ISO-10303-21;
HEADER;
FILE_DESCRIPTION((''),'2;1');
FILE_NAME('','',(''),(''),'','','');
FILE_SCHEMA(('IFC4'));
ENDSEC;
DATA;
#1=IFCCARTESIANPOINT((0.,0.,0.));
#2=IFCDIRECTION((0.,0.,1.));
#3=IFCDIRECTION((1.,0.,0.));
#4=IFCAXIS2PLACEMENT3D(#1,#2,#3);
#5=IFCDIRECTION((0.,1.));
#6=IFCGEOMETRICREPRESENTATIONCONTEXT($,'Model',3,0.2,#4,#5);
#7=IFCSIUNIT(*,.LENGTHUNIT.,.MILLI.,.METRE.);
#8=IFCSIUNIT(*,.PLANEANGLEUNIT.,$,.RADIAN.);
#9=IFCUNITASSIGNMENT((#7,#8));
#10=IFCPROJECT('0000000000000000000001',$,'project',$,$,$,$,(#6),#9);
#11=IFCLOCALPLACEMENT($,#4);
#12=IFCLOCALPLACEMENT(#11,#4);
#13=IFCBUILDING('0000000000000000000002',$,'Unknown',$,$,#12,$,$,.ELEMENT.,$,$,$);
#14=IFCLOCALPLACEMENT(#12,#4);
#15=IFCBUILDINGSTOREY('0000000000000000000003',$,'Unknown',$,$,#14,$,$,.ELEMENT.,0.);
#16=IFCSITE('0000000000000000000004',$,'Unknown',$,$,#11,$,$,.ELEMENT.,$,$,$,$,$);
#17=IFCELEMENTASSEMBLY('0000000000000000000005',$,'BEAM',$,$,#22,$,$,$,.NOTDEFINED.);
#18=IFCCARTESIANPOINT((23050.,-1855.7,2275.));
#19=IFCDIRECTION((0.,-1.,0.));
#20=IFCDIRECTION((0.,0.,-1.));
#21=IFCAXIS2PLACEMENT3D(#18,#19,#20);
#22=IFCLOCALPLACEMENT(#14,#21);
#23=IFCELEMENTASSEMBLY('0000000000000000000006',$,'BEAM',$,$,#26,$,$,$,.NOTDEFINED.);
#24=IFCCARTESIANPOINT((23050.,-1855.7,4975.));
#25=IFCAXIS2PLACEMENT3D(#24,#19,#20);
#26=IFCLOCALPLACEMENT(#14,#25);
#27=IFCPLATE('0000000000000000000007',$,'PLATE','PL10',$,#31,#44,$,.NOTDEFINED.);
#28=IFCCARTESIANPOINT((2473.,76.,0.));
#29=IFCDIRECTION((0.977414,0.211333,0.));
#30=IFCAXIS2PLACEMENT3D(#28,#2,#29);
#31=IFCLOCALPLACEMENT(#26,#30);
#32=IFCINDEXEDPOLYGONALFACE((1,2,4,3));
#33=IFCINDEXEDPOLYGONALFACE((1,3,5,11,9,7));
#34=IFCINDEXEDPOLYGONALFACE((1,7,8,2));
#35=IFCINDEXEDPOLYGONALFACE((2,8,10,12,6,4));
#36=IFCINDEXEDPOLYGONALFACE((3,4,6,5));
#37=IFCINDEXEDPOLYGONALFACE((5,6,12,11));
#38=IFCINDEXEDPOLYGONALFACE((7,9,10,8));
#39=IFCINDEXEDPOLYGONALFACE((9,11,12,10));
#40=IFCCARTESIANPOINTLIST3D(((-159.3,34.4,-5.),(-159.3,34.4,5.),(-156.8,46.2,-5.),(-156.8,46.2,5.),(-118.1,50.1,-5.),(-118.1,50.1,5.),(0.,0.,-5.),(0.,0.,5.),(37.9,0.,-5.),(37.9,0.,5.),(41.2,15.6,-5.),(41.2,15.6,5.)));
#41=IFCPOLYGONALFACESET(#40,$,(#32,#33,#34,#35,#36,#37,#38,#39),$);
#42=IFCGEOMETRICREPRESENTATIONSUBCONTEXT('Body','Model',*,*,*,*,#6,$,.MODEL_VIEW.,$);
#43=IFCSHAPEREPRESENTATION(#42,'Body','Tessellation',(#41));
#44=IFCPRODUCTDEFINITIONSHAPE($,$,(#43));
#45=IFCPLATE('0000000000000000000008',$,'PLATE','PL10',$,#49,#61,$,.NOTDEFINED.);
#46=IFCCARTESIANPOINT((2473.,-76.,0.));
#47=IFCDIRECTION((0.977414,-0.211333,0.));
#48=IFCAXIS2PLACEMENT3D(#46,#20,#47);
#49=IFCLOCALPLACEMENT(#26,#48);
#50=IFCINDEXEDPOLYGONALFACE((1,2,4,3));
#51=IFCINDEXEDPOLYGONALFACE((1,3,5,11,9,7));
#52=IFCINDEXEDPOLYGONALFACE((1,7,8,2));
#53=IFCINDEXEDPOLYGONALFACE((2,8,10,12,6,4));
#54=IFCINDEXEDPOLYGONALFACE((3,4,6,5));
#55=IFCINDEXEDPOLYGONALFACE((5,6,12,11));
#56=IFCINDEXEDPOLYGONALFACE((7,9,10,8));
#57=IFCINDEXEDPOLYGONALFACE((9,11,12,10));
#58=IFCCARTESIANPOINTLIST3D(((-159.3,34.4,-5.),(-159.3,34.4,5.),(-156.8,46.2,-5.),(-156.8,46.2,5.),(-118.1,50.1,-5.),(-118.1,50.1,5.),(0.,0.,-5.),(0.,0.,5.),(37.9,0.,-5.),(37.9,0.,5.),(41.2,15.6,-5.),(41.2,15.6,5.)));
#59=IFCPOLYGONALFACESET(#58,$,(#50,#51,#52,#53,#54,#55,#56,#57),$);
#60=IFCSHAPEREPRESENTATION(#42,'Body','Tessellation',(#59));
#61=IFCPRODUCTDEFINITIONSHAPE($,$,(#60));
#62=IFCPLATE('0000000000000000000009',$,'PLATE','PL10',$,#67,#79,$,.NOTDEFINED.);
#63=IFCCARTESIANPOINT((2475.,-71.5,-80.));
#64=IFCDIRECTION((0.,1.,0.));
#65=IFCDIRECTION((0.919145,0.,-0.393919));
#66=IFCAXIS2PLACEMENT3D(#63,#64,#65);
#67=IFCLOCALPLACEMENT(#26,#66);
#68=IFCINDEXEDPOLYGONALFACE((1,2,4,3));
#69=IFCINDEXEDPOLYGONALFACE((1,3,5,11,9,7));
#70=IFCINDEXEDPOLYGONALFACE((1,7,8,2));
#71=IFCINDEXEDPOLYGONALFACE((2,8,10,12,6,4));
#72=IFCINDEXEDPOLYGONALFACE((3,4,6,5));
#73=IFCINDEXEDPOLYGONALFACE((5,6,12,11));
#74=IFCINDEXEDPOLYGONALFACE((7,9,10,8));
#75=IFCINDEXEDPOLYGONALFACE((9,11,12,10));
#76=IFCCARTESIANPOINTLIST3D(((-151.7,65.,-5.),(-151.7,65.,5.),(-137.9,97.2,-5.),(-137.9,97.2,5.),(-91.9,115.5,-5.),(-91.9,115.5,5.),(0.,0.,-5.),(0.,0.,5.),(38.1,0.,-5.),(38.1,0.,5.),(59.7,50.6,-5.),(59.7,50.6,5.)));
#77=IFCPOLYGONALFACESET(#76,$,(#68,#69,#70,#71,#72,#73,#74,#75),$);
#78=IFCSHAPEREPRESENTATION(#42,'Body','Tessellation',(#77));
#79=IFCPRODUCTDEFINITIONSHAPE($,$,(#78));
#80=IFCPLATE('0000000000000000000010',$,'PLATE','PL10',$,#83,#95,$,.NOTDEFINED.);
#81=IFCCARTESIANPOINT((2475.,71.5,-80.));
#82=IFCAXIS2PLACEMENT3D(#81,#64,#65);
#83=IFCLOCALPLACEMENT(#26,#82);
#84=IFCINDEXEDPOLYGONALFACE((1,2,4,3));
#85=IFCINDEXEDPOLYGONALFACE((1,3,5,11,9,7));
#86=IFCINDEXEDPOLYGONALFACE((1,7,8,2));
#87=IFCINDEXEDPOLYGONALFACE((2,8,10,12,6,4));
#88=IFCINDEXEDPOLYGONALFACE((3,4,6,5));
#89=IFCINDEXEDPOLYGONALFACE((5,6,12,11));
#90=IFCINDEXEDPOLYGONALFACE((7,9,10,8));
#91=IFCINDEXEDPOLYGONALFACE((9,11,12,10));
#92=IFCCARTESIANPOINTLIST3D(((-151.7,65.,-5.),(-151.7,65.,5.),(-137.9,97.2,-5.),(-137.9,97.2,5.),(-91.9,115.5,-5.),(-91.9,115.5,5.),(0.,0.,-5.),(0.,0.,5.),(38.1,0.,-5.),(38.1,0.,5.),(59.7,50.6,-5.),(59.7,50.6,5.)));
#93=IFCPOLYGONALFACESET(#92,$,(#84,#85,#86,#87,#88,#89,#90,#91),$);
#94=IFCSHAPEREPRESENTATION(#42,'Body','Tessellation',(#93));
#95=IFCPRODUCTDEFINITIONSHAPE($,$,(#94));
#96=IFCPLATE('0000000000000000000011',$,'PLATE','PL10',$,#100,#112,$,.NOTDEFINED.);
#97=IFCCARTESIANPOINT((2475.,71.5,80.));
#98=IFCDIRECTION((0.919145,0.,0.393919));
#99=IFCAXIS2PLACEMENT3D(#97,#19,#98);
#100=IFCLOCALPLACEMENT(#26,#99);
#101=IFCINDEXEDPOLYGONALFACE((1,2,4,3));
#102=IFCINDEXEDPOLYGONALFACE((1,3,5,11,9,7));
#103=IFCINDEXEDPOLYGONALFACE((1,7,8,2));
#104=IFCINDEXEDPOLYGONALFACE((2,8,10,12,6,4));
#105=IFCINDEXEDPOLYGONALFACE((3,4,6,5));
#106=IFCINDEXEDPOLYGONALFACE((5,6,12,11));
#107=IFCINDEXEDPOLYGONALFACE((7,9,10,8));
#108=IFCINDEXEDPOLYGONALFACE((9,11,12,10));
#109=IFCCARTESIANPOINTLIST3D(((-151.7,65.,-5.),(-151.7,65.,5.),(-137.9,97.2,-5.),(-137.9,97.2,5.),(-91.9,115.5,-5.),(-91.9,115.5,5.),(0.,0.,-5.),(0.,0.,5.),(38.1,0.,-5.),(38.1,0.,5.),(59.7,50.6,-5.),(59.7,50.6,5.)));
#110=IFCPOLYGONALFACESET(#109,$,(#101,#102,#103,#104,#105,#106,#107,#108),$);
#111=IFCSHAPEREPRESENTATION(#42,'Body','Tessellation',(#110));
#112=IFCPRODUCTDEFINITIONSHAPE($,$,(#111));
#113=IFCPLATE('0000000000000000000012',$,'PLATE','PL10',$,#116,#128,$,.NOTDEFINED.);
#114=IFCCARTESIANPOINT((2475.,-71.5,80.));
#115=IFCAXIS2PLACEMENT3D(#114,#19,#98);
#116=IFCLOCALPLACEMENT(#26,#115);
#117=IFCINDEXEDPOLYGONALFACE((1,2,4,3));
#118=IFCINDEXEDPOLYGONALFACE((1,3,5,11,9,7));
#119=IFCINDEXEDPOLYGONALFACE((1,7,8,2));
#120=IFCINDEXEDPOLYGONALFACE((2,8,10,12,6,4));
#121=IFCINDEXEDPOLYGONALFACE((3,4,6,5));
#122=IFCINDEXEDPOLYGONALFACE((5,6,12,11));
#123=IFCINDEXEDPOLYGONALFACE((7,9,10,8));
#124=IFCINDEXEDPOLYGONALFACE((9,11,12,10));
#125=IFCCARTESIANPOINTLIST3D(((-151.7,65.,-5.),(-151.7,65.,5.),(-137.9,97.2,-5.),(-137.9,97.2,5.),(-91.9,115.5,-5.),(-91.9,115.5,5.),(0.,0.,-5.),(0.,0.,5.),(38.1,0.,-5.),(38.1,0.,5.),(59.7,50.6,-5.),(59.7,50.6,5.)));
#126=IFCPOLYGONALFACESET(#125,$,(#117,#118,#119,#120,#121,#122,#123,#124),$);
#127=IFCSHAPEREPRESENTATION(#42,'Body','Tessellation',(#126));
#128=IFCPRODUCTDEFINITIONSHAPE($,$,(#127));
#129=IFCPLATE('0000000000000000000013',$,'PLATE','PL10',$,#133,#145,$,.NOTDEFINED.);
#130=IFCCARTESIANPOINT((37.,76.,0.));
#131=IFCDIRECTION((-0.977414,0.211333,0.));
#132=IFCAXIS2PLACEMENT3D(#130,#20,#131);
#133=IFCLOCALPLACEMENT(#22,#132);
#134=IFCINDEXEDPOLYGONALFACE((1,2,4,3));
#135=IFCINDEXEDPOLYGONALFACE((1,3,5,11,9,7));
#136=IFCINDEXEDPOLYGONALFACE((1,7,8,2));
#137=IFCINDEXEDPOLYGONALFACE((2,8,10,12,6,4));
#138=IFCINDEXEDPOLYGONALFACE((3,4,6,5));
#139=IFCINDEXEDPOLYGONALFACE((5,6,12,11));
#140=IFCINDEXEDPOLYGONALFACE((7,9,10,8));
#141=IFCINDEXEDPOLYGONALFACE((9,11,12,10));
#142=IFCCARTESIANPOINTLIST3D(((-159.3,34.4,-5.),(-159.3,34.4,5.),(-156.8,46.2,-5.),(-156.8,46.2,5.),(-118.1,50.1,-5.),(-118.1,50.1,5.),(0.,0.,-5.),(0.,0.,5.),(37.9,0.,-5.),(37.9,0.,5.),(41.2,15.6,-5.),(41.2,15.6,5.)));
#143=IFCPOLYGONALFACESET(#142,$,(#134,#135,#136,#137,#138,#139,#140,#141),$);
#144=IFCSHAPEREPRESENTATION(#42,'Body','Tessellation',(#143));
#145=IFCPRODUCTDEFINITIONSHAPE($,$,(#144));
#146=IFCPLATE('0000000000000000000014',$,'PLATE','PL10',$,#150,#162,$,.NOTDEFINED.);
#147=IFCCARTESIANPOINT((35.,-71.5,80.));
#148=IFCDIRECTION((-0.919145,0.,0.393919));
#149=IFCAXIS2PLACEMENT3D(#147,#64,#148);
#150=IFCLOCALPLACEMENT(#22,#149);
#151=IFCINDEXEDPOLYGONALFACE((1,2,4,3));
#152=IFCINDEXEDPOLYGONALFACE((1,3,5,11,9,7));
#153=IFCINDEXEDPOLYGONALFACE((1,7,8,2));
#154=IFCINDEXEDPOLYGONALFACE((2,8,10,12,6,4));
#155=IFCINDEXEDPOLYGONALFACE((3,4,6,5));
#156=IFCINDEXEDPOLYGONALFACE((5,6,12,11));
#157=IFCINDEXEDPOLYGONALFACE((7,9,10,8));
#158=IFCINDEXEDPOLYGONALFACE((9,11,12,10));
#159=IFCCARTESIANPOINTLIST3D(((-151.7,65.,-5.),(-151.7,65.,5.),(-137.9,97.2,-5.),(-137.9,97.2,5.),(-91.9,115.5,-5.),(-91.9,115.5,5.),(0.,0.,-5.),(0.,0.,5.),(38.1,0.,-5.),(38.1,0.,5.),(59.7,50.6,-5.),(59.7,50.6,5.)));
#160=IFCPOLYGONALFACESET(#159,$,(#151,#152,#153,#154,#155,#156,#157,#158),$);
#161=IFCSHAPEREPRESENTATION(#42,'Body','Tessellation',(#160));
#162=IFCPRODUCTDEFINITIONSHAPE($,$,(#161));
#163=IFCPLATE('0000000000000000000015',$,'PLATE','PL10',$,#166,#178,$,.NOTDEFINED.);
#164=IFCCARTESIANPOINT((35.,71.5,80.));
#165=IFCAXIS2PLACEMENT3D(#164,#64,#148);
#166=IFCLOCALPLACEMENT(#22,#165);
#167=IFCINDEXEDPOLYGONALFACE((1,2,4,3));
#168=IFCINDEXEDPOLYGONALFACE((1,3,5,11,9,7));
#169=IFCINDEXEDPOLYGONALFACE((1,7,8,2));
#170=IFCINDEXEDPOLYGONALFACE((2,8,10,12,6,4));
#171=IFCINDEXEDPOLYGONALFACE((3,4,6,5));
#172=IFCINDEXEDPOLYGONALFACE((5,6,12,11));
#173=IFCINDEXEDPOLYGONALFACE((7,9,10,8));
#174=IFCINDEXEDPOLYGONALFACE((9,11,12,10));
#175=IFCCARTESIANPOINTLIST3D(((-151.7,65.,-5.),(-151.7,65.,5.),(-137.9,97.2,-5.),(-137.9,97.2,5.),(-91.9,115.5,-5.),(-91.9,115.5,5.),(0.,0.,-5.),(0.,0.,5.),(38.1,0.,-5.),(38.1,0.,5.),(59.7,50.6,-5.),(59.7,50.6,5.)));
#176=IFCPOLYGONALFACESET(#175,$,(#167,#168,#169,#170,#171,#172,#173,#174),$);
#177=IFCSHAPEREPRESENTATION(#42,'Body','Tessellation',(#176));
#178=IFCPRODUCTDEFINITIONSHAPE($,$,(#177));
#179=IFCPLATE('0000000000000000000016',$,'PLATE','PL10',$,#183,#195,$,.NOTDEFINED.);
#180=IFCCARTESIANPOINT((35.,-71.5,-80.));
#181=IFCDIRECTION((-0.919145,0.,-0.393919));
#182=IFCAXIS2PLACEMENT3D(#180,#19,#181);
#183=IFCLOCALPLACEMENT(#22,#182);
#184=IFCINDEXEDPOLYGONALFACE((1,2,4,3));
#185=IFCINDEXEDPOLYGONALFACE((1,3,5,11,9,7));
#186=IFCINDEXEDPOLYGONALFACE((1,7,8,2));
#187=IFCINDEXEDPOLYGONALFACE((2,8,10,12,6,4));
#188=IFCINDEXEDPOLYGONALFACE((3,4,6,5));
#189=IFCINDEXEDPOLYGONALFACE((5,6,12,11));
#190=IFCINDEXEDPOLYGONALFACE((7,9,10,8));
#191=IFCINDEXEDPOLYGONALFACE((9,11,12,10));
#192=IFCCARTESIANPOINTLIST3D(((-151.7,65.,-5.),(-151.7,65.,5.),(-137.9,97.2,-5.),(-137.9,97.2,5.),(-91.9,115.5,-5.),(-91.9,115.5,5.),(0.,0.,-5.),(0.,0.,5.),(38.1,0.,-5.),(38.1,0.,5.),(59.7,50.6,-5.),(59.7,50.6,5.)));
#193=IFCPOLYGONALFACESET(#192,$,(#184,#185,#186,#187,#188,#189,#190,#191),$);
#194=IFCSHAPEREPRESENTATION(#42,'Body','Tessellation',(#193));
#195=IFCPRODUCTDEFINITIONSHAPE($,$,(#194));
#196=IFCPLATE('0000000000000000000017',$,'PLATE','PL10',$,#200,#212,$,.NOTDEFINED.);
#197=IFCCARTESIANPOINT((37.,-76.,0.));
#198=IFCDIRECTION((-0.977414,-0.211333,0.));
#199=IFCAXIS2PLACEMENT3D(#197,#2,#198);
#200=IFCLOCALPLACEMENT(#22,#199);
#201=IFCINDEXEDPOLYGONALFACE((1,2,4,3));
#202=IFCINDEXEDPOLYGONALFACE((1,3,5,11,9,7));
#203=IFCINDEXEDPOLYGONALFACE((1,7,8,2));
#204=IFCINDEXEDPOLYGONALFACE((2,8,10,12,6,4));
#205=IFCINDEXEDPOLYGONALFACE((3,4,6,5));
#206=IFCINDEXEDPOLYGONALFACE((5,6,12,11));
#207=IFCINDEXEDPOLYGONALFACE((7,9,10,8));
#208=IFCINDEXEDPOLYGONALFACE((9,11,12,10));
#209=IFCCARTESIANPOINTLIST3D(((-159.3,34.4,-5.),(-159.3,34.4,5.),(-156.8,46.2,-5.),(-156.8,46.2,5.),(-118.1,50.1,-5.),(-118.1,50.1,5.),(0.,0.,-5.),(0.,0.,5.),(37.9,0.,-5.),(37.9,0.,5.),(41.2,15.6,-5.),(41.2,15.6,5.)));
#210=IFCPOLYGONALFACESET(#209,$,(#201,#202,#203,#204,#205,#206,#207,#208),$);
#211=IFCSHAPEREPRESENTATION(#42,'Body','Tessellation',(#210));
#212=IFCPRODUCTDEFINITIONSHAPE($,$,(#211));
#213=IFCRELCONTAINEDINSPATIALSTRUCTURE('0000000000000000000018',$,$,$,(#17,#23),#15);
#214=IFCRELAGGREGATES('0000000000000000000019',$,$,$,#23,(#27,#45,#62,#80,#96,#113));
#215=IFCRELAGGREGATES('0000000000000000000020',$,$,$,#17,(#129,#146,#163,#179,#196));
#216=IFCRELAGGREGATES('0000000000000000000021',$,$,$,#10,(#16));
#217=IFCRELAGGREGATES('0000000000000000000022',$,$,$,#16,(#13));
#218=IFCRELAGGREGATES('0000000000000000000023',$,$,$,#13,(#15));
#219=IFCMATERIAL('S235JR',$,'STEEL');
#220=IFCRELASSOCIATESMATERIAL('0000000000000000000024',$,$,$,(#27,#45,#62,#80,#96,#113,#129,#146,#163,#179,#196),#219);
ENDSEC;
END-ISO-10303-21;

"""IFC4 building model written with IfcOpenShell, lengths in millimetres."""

from ifc_helpers import new_model, si_unit, direction, frame, origin_with_axes, place, context, subcontext, project, spatial, line, indexed_curve, outline, extrude, material, element, aggregate, save


model = new_model("IFC4")

# Units and contexts
model_context = context("Model", 3, precision=0.2, world=origin_with_axes(), true_north=direction((0.0, 1.0)))
body_context = subcontext(model_context, "Body", "Model", "MODEL_VIEW")
ifc_project = project(units=[si_unit("LENGTHUNIT", "METRE", prefix="MILLI"), si_unit("PLANEANGLEUNIT", "RADIAN")], contexts=[model_context])

# Site, building, storey
site_placement = place(None, origin_with_axes())
site = spatial("IfcSite", under=ifc_project, at=site_placement, Name="Unknown", CompositionType="ELEMENT")
building_placement = place(site_placement, origin_with_axes())
building = spatial("IfcBuilding", under=site, at=building_placement, Name="Unknown", CompositionType="ELEMENT")
storey_placement = place(building_placement, origin_with_axes())
storey = spatial("IfcBuildingStorey", under=building, at=storey_placement, Name="Unknown", CompositionType="ELEMENT", Elevation=0.0)

# Shared definitions
ifc_material_1 = material(Name="S235JR", Category="STEEL")

# Element assembly
assembly_1_placement = place(storey_placement, frame((23050.0, -1855.7, 2275.0), z_axis=(0.0, -1.0, 0.0), x_axis=(0.0, 0.0, -1.0)))
assembly_1 = element("IfcElementAssembly", 1, at=assembly_1_placement, inside=storey, Name="BEAM", PredefinedType="NOTDEFINED")

# Element assembly, plates
assembly_2_placement = place(storey_placement, frame((23050.0, -1855.7, 4975.0), z_axis=(0.0, -1.0, 0.0), x_axis=(0.0, 0.0, -1.0)))
assembly_2 = element("IfcElementAssembly", 2, at=assembly_2_placement, inside=storey, Name="BEAM", PredefinedType="NOTDEFINED")
plate_1_placement = place(assembly_2_placement, frame((2473.0, 76.0, 0.0), z_axis=(0.0, 0.0, 1.0), x_axis=(0.977414, 0.211333, 0.0)))
plate_1 = element("IfcPlate", 3, at=plate_1_placement, material=ifc_material_1, Name="PLATE", Description="PL10", PredefinedType="NOTDEFINED", context=body_context, shape_type="SolidModel", body=[
    extrude(outline(indexed_curve([(0.0, 0.0), (37.9, 0.0), (41.2, 15.6), (-118.1, 50.1), (-156.8, 46.2), (-159.3, 34.4)], segments=[line(1, 2, 3, 4, 5, 6, 1)])), frame((0.0, 0.0, 5.0), z_axis=(0.0, 0.0, 1.0), x_axis=(1.0, 0.0, 0.0)), (0.0, 0.0, -1.0), 10.0),
])
plate_2_placement = place(assembly_2_placement, frame((2473.0, -76.0, 0.0), z_axis=(0.0, 0.0, -1.0), x_axis=(0.977414, -0.211333, 0.0)))
plate_2 = element("IfcPlate", 4, at=plate_2_placement, material=ifc_material_1, Name="PLATE", Description="PL10", PredefinedType="NOTDEFINED", context=body_context, shape_type="SolidModel", body=[
    extrude(outline(indexed_curve([(0.0, 0.0), (37.9, 0.0), (41.2, 15.6), (-118.1, 50.1), (-156.8, 46.2), (-159.3, 34.4)], segments=[line(1, 2, 3, 4, 5, 6, 1)])), frame((0.0, 0.0, 5.0), z_axis=(0.0, 0.0, 1.0), x_axis=(1.0, 0.0, 0.0)), (0.0, 0.0, -1.0), 10.0),
])
plate_3_placement = place(assembly_2_placement, frame((2475.0, -71.5, -80.0), z_axis=(0.0, 1.0, 0.0), x_axis=(0.919145, 0.0, -0.393919)))
plate_3 = element("IfcPlate", 5, at=plate_3_placement, material=ifc_material_1, Name="PLATE", Description="PL10", PredefinedType="NOTDEFINED", context=body_context, shape_type="SolidModel", body=[
    extrude(outline(indexed_curve([(0.0, 0.0), (38.1, 0.0), (59.7, 50.6), (-91.9, 115.5), (-137.9, 97.2), (-151.7, 65.0)], segments=[line(1, 2, 3, 4, 5, 6, 1)])), frame((0.0, 0.0, 5.0), z_axis=(0.0, 0.0, 1.0), x_axis=(1.0, 0.0, 0.0)), (0.0, 0.0, -1.0), 10.0),
])
plate_4_placement = place(assembly_2_placement, frame((2475.0, 71.5, -80.0), z_axis=(0.0, 1.0, 0.0), x_axis=(0.919145, 0.0, -0.393919)))
plate_4 = element("IfcPlate", 6, at=plate_4_placement, material=ifc_material_1, Name="PLATE", Description="PL10", PredefinedType="NOTDEFINED", context=body_context, shape_type="SolidModel", body=[
    extrude(outline(indexed_curve([(0.0, 0.0), (38.1, 0.0), (59.7, 50.6), (-91.9, 115.5), (-137.9, 97.2), (-151.7, 65.0)], segments=[line(1, 2, 3, 4, 5, 6, 1)])), frame((0.0, 0.0, 5.0), z_axis=(0.0, 0.0, 1.0), x_axis=(1.0, 0.0, 0.0)), (0.0, 0.0, -1.0), 10.0),
])
plate_5_placement = place(assembly_2_placement, frame((2475.0, 71.5, 80.0), z_axis=(0.0, -1.0, 0.0), x_axis=(0.919145, 0.0, 0.393919)))
plate_5 = element("IfcPlate", 7, at=plate_5_placement, material=ifc_material_1, Name="PLATE", Description="PL10", PredefinedType="NOTDEFINED", context=body_context, shape_type="SolidModel", body=[
    extrude(outline(indexed_curve([(0.0, 0.0), (38.1, 0.0), (59.7, 50.6), (-91.9, 115.5), (-137.9, 97.2), (-151.7, 65.0)], segments=[line(1, 2, 3, 4, 5, 6, 1)])), frame((0.0, 0.0, 5.0), z_axis=(0.0, 0.0, 1.0), x_axis=(1.0, 0.0, 0.0)), (0.0, 0.0, -1.0), 10.0),
])
plate_6_placement = place(assembly_2_placement, frame((2475.0, -71.5, 80.0), z_axis=(0.0, -1.0, 0.0), x_axis=(0.919145, 0.0, 0.393919)))
plate_6 = element("IfcPlate", 8, at=plate_6_placement, material=ifc_material_1, Name="PLATE", Description="PL10", PredefinedType="NOTDEFINED", context=body_context, shape_type="SolidModel", body=[
    extrude(outline(indexed_curve([(0.0, 0.0), (38.1, 0.0), (59.7, 50.6), (-91.9, 115.5), (-137.9, 97.2), (-151.7, 65.0)], segments=[line(1, 2, 3, 4, 5, 6, 1)])), frame((0.0, 0.0, 5.0), z_axis=(0.0, 0.0, 1.0), x_axis=(1.0, 0.0, 0.0)), (0.0, 0.0, -1.0), 10.0),
])
aggregate(assembly_2, [plate_1, plate_2, plate_3, plate_4, plate_5, plate_6])

# Plates
plate_7_placement = place(assembly_1_placement, frame((37.0, 76.0, 0.0), z_axis=(0.0, 0.0, -1.0), x_axis=(-0.977414, 0.211333, 0.0)))
plate_7 = element("IfcPlate", 9, at=plate_7_placement, material=ifc_material_1, Name="PLATE", Description="PL10", PredefinedType="NOTDEFINED", context=body_context, shape_type="SolidModel", body=[
    extrude(outline(indexed_curve([(0.0, 0.0), (37.9, 0.0), (41.2, 15.6), (-118.1, 50.1), (-156.8, 46.2), (-159.3, 34.4)], segments=[line(1, 2, 3, 4, 5, 6, 1)])), frame((0.0, 0.0, 5.0), z_axis=(0.0, 0.0, 1.0), x_axis=(1.0, 0.0, 0.0)), (0.0, 0.0, -1.0), 10.0),
])
plate_8_placement = place(assembly_1_placement, frame((35.0, -71.5, 80.0), z_axis=(0.0, 1.0, 0.0), x_axis=(-0.919145, 0.0, 0.393919)))
plate_8 = element("IfcPlate", 10, at=plate_8_placement, material=ifc_material_1, Name="PLATE", Description="PL10", PredefinedType="NOTDEFINED", context=body_context, shape_type="SolidModel", body=[
    extrude(outline(indexed_curve([(0.0, 0.0), (38.1, 0.0), (59.7, 50.6), (-91.9, 115.5), (-137.9, 97.2), (-151.7, 65.0)], segments=[line(1, 2, 3, 4, 5, 6, 1)])), frame((0.0, 0.0, 5.0), z_axis=(0.0, 0.0, 1.0), x_axis=(1.0, 0.0, 0.0)), (0.0, 0.0, -1.0), 10.0),
])
plate_9_placement = place(assembly_1_placement, frame((35.0, 71.5, 80.0), z_axis=(0.0, 1.0, 0.0), x_axis=(-0.919145, 0.0, 0.393919)))
plate_9 = element("IfcPlate", 11, at=plate_9_placement, material=ifc_material_1, Name="PLATE", Description="PL10", PredefinedType="NOTDEFINED", context=body_context, shape_type="SolidModel", body=[
    extrude(outline(indexed_curve([(0.0, 0.0), (38.1, 0.0), (59.7, 50.6), (-91.9, 115.5), (-137.9, 97.2), (-151.7, 65.0)], segments=[line(1, 2, 3, 4, 5, 6, 1)])), frame((0.0, 0.0, 5.0), z_axis=(0.0, 0.0, 1.0), x_axis=(1.0, 0.0, 0.0)), (0.0, 0.0, -1.0), 10.0),
])
plate_10_placement = place(assembly_1_placement, frame((35.0, -71.5, -80.0), z_axis=(0.0, -1.0, 0.0), x_axis=(-0.919145, 0.0, -0.393919)))
plate_10 = element("IfcPlate", 12, at=plate_10_placement, material=ifc_material_1, Name="PLATE", Description="PL10", PredefinedType="NOTDEFINED", context=body_context, shape_type="SolidModel", body=[
    extrude(outline(indexed_curve([(0.0, 0.0), (38.1, 0.0), (59.7, 50.6), (-91.9, 115.5), (-137.9, 97.2), (-151.7, 65.0)], segments=[line(1, 2, 3, 4, 5, 6, 1)])), frame((0.0, 0.0, 5.0), z_axis=(0.0, 0.0, 1.0), x_axis=(1.0, 0.0, 0.0)), (0.0, 0.0, -1.0), 10.0),
])
plate_11_placement = place(assembly_1_placement, frame((37.0, -76.0, 0.0), z_axis=(0.0, 0.0, 1.0), x_axis=(-0.977414, -0.211333, 0.0)))
plate_11 = element("IfcPlate", 13, at=plate_11_placement, material=ifc_material_1, Name="PLATE", Description="PL10", PredefinedType="NOTDEFINED", context=body_context, shape_type="SolidModel", body=[
    extrude(outline(indexed_curve([(0.0, 0.0), (37.9, 0.0), (41.2, 15.6), (-118.1, 50.1), (-156.8, 46.2), (-159.3, 34.4)], segments=[line(1, 2, 3, 4, 5, 6, 1)])), frame((0.0, 0.0, 5.0), z_axis=(0.0, 0.0, 1.0), x_axis=(1.0, 0.0, 0.0)), (0.0, 0.0, -1.0), 10.0),
])

aggregate(assembly_1, [plate_7, plate_8, plate_9, plate_10, plate_11])

save(model, "model.ifc")
